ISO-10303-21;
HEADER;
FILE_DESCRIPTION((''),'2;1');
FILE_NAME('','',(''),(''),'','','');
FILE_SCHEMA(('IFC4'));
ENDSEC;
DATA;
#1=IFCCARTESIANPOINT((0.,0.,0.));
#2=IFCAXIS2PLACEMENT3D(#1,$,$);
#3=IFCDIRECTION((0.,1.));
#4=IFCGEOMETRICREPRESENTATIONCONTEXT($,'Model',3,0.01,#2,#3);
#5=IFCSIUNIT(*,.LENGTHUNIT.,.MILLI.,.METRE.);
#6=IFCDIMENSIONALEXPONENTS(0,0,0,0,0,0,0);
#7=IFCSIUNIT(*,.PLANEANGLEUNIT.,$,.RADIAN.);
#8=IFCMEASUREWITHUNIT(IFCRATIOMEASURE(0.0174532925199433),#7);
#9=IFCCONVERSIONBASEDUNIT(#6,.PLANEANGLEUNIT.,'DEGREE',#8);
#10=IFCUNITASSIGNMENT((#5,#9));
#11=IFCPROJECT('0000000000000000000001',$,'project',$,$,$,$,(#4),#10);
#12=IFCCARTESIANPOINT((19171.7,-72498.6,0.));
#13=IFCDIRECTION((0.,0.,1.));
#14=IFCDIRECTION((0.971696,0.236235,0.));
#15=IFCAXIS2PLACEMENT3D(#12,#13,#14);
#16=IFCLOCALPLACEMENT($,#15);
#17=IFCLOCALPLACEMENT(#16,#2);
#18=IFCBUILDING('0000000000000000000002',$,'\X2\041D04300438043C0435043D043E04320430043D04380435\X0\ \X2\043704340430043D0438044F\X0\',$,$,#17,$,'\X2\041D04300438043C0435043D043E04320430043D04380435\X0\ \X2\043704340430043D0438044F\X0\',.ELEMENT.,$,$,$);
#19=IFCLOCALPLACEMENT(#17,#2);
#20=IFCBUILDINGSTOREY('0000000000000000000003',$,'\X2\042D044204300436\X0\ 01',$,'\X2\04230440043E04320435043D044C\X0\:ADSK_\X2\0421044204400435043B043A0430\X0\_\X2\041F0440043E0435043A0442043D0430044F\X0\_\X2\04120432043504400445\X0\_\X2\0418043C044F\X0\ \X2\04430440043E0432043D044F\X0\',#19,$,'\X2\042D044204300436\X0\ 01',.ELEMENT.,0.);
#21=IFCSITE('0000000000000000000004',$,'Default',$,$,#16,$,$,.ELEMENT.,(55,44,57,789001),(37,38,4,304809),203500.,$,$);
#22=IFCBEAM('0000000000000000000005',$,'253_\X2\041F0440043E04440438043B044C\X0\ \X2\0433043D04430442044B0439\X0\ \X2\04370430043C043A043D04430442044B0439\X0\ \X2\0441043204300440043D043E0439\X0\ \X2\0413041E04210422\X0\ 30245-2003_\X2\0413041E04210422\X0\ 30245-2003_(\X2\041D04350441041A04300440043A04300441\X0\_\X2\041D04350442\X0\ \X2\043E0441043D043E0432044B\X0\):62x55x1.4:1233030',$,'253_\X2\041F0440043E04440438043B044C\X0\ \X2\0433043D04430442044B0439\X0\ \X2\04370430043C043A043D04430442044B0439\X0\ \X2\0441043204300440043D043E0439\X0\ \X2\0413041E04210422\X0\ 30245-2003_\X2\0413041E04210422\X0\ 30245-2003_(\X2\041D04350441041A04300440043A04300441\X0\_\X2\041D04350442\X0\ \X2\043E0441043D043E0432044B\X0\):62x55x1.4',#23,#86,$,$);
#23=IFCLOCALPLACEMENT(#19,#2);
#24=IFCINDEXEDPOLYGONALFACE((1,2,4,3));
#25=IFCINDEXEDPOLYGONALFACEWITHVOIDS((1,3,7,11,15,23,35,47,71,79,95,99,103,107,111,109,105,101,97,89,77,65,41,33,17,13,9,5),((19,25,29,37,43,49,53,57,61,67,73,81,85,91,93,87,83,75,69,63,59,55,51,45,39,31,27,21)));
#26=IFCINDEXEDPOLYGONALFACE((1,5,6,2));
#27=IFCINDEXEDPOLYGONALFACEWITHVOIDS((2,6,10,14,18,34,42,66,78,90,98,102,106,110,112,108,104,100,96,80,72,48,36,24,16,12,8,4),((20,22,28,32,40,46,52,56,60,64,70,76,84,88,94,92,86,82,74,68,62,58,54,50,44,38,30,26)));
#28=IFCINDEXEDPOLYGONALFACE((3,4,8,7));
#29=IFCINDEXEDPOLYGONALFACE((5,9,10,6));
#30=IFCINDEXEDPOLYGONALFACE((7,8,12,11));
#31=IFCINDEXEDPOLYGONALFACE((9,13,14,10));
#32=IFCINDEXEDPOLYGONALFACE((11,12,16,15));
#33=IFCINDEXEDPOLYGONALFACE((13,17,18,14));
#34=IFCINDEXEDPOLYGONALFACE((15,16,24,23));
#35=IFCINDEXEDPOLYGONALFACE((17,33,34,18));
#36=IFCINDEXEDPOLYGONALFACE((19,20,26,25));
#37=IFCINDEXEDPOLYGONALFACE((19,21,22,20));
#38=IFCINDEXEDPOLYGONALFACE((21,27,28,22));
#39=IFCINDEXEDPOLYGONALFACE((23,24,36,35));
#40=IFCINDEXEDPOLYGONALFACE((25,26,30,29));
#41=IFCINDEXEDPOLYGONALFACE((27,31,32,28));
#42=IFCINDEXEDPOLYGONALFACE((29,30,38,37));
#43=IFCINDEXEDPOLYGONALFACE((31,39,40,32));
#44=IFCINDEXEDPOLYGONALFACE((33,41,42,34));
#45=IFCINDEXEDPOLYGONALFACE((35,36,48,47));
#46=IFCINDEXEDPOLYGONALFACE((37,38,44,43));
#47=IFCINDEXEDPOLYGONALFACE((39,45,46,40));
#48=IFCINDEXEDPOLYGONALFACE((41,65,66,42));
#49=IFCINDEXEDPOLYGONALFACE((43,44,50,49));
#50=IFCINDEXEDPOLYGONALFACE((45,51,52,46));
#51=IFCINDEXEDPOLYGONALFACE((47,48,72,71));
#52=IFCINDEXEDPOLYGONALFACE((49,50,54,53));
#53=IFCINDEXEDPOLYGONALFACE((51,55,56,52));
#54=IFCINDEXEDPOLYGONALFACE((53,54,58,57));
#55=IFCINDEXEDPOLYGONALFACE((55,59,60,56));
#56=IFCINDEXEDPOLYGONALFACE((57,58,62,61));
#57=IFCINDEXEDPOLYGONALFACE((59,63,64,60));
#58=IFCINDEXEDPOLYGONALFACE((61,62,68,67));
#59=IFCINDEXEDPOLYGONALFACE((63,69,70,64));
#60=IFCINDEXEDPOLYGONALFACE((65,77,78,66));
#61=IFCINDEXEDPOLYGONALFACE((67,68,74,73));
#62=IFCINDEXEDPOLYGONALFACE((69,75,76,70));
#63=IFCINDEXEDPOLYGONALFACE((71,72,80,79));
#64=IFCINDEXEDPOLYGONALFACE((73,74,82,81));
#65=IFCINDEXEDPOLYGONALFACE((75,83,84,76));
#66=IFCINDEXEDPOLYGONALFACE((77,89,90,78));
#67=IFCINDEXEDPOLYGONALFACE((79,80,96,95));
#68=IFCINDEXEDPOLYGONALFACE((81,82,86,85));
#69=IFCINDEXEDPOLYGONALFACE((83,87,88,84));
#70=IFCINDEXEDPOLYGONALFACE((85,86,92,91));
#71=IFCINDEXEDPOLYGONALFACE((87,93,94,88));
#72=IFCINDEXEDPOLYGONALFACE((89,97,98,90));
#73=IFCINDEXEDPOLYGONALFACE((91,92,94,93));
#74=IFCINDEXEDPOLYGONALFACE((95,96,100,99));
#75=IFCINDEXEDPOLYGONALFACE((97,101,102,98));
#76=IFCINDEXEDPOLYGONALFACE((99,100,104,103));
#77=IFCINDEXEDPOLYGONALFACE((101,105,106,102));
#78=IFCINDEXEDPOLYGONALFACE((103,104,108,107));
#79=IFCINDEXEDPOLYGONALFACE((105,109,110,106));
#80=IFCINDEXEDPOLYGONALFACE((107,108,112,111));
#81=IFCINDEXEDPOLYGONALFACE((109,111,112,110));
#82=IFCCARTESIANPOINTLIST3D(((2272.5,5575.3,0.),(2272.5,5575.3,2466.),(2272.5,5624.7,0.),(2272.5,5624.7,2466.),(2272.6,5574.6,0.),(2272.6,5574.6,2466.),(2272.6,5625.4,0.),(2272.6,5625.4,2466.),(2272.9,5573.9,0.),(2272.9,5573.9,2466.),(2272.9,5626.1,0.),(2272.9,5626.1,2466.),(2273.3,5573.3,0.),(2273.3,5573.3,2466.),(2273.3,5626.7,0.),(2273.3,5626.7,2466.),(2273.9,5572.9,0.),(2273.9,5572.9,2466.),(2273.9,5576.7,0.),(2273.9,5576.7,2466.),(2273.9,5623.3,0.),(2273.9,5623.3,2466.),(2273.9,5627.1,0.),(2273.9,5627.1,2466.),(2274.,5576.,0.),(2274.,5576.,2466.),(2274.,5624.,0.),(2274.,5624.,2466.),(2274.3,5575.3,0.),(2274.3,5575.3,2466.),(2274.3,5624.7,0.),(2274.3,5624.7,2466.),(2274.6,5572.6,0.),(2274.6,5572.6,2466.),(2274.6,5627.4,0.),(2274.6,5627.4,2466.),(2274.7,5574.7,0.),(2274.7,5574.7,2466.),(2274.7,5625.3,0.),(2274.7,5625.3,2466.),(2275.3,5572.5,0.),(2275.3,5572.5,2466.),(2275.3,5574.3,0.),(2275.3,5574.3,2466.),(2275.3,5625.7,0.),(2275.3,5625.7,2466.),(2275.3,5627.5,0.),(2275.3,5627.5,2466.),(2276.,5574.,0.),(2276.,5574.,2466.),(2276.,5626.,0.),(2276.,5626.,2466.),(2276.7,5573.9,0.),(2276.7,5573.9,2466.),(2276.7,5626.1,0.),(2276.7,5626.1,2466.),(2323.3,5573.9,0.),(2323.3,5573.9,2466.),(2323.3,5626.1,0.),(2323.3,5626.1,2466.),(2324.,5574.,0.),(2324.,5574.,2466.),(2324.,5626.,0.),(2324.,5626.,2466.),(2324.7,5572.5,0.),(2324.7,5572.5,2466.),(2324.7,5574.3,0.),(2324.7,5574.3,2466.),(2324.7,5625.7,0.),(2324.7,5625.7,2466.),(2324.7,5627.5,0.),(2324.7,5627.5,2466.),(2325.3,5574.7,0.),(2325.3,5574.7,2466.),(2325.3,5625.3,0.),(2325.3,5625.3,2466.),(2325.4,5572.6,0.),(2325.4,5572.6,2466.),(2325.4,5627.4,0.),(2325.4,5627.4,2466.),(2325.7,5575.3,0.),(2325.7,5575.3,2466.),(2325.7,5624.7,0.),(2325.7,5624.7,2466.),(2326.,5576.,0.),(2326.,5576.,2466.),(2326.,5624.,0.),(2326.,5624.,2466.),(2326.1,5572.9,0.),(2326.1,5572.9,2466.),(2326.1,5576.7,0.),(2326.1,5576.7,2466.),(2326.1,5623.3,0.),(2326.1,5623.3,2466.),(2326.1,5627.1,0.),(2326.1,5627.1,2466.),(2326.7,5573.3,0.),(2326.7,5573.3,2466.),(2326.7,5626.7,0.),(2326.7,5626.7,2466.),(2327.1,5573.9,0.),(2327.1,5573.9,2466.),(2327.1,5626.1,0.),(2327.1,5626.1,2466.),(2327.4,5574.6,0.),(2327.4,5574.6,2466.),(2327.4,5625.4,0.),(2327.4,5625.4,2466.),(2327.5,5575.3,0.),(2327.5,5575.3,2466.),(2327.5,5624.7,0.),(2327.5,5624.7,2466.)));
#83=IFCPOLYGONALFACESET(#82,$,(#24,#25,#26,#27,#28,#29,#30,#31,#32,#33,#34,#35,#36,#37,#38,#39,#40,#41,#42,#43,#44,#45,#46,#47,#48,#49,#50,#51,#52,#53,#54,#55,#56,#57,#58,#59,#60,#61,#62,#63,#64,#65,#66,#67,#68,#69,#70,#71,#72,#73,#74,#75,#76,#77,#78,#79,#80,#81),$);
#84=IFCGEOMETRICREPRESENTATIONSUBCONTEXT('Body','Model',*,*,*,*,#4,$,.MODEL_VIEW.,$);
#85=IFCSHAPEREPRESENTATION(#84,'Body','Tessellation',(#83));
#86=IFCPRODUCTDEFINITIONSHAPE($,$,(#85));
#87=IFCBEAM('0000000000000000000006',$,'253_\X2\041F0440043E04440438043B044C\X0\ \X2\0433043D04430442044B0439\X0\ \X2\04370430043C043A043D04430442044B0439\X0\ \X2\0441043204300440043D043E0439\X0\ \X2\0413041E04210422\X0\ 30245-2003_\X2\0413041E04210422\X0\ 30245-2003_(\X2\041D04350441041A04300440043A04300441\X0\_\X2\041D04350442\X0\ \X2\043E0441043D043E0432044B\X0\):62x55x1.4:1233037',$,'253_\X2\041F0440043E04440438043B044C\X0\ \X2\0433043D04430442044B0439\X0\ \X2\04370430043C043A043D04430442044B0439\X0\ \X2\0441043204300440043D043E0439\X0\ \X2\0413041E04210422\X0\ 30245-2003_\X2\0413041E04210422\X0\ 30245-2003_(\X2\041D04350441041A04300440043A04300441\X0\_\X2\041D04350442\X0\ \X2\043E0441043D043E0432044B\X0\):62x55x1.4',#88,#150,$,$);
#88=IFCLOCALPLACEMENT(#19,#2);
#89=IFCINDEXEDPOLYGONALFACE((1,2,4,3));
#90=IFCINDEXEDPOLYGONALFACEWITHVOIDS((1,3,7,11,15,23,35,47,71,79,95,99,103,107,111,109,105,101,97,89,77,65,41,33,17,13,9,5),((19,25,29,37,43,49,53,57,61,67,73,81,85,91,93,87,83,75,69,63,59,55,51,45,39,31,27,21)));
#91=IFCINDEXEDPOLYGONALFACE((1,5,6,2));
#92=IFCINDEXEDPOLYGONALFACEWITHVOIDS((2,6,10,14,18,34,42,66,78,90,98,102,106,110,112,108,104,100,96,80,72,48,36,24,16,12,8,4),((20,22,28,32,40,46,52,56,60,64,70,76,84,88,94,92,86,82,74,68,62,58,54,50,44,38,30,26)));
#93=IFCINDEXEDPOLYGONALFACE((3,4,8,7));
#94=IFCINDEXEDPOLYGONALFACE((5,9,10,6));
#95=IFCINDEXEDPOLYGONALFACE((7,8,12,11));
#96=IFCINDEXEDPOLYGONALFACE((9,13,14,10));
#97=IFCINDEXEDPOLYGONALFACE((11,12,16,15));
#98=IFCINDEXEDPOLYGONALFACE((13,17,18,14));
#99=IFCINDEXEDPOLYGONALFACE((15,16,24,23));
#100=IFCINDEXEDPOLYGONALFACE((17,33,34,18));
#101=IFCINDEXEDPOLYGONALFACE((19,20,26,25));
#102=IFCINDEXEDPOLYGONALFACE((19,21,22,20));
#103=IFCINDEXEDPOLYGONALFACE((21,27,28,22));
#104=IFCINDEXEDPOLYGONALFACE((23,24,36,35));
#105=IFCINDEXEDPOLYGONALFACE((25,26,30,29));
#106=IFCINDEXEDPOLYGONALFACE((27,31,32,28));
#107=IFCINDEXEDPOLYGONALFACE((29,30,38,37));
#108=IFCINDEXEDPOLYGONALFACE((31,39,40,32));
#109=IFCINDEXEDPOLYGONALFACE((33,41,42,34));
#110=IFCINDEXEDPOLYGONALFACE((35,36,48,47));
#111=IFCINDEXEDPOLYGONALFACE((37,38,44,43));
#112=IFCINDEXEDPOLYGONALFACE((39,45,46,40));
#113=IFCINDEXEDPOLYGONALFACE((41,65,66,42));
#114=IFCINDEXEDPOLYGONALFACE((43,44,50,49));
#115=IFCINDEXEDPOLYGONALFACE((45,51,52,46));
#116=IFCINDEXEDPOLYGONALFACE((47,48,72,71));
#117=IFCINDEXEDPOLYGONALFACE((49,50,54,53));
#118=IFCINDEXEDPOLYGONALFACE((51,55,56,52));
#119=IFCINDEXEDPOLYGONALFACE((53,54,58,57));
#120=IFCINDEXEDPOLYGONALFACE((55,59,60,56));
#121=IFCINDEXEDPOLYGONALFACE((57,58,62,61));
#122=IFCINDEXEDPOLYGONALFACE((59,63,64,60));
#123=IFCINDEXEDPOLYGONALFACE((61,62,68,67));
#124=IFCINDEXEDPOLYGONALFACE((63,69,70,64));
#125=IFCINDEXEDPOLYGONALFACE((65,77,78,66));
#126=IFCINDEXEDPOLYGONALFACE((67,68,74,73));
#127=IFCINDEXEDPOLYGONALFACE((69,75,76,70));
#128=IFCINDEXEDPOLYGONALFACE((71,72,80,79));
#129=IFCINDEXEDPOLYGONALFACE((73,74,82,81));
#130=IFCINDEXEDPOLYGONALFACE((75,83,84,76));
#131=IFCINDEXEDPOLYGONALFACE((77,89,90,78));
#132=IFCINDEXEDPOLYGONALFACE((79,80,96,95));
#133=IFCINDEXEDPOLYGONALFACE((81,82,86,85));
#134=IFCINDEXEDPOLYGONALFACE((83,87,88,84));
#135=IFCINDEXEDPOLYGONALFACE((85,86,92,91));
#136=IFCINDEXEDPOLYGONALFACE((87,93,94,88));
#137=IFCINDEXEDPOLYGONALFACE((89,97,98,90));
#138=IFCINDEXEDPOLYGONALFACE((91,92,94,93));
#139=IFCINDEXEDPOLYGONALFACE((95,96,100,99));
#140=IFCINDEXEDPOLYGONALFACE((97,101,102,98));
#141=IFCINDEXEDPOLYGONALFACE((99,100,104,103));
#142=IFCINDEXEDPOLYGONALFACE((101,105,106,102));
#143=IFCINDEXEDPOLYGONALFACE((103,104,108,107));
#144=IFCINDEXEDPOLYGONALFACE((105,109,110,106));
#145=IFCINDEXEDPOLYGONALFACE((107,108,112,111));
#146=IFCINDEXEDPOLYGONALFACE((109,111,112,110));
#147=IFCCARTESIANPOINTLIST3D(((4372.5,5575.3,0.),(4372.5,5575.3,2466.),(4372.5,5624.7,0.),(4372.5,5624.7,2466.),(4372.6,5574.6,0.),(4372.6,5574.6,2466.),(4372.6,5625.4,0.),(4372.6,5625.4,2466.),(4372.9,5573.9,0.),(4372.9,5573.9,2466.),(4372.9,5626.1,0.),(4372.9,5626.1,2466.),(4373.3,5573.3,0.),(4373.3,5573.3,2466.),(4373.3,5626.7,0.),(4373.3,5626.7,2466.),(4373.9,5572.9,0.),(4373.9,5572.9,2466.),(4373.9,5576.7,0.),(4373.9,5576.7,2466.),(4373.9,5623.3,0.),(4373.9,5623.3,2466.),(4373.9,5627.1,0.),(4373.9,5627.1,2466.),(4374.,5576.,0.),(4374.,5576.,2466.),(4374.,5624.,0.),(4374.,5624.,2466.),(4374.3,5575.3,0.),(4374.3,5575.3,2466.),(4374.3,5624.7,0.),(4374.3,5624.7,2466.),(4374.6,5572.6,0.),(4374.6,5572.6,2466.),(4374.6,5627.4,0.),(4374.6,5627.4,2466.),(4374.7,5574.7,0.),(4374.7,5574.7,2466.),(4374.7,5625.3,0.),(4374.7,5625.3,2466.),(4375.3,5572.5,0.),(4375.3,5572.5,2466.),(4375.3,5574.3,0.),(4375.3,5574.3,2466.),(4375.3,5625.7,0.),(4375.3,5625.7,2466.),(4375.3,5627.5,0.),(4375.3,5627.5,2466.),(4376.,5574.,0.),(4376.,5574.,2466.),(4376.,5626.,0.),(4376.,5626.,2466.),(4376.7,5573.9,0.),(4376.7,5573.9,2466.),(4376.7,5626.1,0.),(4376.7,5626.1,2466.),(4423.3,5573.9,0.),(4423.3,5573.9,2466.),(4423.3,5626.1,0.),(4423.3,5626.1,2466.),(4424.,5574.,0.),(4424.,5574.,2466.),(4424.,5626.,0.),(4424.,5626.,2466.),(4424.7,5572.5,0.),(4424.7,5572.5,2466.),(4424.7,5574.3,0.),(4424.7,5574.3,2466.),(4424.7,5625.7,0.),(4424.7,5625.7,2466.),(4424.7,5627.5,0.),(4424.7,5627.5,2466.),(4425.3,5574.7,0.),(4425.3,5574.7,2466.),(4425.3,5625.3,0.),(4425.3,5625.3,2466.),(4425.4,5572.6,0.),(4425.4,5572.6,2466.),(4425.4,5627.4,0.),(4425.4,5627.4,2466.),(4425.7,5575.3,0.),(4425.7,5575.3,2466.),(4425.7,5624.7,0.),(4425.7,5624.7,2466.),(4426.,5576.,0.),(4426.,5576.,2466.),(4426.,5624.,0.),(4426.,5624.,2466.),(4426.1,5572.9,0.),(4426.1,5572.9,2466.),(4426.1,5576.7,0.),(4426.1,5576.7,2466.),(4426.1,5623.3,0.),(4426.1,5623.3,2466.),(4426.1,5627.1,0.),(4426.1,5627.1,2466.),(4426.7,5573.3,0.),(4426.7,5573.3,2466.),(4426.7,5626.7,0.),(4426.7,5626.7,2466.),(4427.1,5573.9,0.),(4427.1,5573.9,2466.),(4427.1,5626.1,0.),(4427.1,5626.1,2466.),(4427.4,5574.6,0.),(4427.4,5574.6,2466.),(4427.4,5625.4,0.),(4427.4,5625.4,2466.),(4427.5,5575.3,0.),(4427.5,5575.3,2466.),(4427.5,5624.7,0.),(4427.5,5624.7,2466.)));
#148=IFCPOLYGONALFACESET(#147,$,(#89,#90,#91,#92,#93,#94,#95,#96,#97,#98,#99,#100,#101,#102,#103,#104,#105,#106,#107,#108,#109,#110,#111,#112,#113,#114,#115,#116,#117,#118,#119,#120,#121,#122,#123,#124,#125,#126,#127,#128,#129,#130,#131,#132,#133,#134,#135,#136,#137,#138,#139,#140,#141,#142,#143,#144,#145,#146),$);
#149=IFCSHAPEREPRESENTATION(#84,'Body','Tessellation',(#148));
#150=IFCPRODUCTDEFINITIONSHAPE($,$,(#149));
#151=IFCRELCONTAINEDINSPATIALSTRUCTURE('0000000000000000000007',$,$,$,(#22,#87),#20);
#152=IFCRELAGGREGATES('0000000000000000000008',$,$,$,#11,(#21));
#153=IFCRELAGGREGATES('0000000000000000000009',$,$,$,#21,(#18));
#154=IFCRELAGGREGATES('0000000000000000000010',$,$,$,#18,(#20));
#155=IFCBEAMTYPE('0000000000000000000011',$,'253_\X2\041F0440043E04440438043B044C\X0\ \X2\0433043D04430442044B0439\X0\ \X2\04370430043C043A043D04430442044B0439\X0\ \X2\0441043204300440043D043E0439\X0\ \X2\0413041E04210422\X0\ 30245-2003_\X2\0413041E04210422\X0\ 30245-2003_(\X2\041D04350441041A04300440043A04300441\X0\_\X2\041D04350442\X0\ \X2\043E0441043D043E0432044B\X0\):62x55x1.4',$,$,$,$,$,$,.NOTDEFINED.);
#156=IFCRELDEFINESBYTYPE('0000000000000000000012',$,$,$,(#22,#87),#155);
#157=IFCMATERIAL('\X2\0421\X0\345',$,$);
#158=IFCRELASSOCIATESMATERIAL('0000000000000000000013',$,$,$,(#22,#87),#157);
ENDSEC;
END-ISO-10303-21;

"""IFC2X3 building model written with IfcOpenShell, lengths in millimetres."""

from ifc_helpers import new_model, entity, si_unit, converted_unit, direction, frame, frame_2d, origin, place, context, subcontext, project, spatial, polyline, circle_curve, parameter, trimmed, segment, composite_curve, outline, extrude, material, type_object, element, save


model = new_model("IFC2X3")

# Units and contexts
model_context = context("Model", 3, precision=0.01, world=origin(), true_north=direction((0.0, 1.0)))
body_context = subcontext(model_context, "Body", "Model", "MODEL_VIEW")
ifc_project = project(units=[si_unit("LENGTHUNIT", "METRE", prefix="MILLI"), converted_unit("PLANEANGLEUNIT", "DEGREE", entity("IfcRatioMeasure", 0.0174532925199433), si_unit("PLANEANGLEUNIT", "RADIAN"), dimensions=[0, 0, 0, 0, 0, 0, 0])], contexts=[model_context])

# Site, building, storey
site_placement = place(None, frame((19171.7, -72498.6, 0.0), z_axis=(0.0, 0.0, 1.0), x_axis=(0.971696, 0.236235, 0.0)))
site = spatial("IfcSite", under=ifc_project, at=site_placement, Name="Default", CompositionType="ELEMENT", RefLatitude=(55, 44, 57, 789001), RefLongitude=(37, 38, 4, 304809), RefElevation=203500.0)
building_placement = place(site_placement, origin())
building = spatial("IfcBuilding", under=site, at=building_placement, Name="Наименование здания", LongName="Наименование здания", CompositionType="ELEMENT")
storey_placement = place(building_placement, origin())
storey = spatial("IfcBuildingStorey", under=building, at=storey_placement, Name="Этаж 01", ObjectType="Уровень:ADSK_Стрелка_Проектная_Вверх_Имя уровня", LongName="Этаж 01", CompositionType="ELEMENT", Elevation=0.0)

# Beams
ifc_material_1 = material(Name="С345")
beam_type_1 = type_object("IfcBeamType", Name="253_Профиль гнутый замкнутый сварной ГОСТ 30245-2003_ГОСТ 30245-2003_(НесКаркас_Нет основы):62x55x1.4", PredefinedType="NOTDEFINED")
beam_1_placement = place(storey_placement, frame((2270.9, 5570.9, 0.0), z_axis=(1.0, 0.0, 0.0), x_axis=(0.0, 0.0, -1.0)))
element("IfcBeam", 1, at=beam_1_placement, inside=storey, type_object=beam_type_1, material=ifc_material_1, Name="253_Профиль гнутый замкнутый сварной ГОСТ 30245-2003_ГОСТ 30245-2003_(НесКаркас_Нет основы):62x55x1.4:1233030", ObjectType="253_Профиль гнутый замкнутый сварной ГОСТ 30245-2003_ГОСТ 30245-2003_(НесКаркас_Нет основы):62x55x1.4", context=body_context, shape_type="SweptSolid", body=[
    extrude(outline(composite_curve([segment(trimmed(circle_curve(frame_2d((24.7, -24.7), x_axis=(1.0, 0.0)), 2.8), [parameter(270.0)], [parameter(0.0)], True, "PARAMETER"), True, "CONTINUOUS"), segment(polyline([(27.5, -24.7), (27.5, 24.7)]), True, "CONTINUOUS"), segment(trimmed(circle_curve(frame_2d((24.7, 24.7), x_axis=(1.0, 0.0)), 2.8), [parameter(0.0)], [parameter(90.0)], True, "PARAMETER"), True, "CONTINUOUS"), segment(polyline([(24.7, 27.5), (-24.7, 27.5)]), True, "CONTINUOUS"), segment(trimmed(circle_curve(frame_2d((-24.7, 24.7), x_axis=(1.0, 0.0)), 2.8), [parameter(90.0)], [parameter(180.0)], True, "PARAMETER"), True, "CONTINUOUS"), segment(polyline([(-27.5, 24.7), (-27.5, -24.7)]), True, "CONTINUOUS"), segment(trimmed(circle_curve(frame_2d((-24.7, -24.7), x_axis=(1.0, 0.0)), 2.8), [parameter(180.0)], [parameter(270.0)], True, "PARAMETER"), True, "CONTINUOUS"), segment(polyline([(-24.7, -27.5), (24.7, -27.5)]), True, "CONTINUOUS")], self_intersect=False), holes=[composite_curve([segment(polyline([(23.3, -26.1), (-23.3, -26.1)]), True, "CONTINUOUS"), segment(trimmed(circle_curve(frame_2d((-23.3, -23.3), x_axis=(1.0, 0.0)), 2.8), [parameter(180.0)], [parameter(270.0)], True, "PARAMETER"), False, "CONTINUOUS"), segment(polyline([(-26.1, -23.3), (-26.1, 23.3)]), True, "CONTINUOUS"), segment(trimmed(circle_curve(frame_2d((-23.3, 23.3), x_axis=(1.0, 0.0)), 2.8), [parameter(90.0)], [parameter(180.0)], True, "PARAMETER"), False, "CONTINUOUS"), segment(polyline([(-23.3, 26.1), (23.3, 26.1)]), True, "CONTINUOUS"), segment(trimmed(circle_curve(frame_2d((23.3, 23.3), x_axis=(1.0, 0.0)), 2.8), [parameter(0.0)], [parameter(90.0)], True, "PARAMETER"), False, "CONTINUOUS"), segment(polyline([(26.1, 23.3), (26.1, -23.3)]), True, "CONTINUOUS"), segment(trimmed(circle_curve(frame_2d((23.3, -23.3), x_axis=(1.0, 0.0)), 2.8), [parameter(270.0)], [parameter(0.0)], True, "PARAMETER"), False, "CONTINUOUS")], self_intersect=False)]), frame((-2466.0, 29.1, 29.1), z_axis=(1.0, 0.0, 0.0), x_axis=(0.0, 1.0, 0.0)), (0.0, 0.0, 1.0), 2466.0),
])
beam_2_placement = place(storey_placement, frame((4370.9, 5570.9, 0.0), z_axis=(1.0, 0.0, 0.0), x_axis=(0.0, 0.0, -1.0)))
element("IfcBeam", 2, at=beam_2_placement, inside=storey, type_object=beam_type_1, material=ifc_material_1, Name="253_Профиль гнутый замкнутый сварной ГОСТ 30245-2003_ГОСТ 30245-2003_(НесКаркас_Нет основы):62x55x1.4:1233037", ObjectType="253_Профиль гнутый замкнутый сварной ГОСТ 30245-2003_ГОСТ 30245-2003_(НесКаркас_Нет основы):62x55x1.4", context=body_context, shape_type="SweptSolid", body=[
    extrude(outline(composite_curve([segment(trimmed(circle_curve(frame_2d((24.7, -24.7), x_axis=(1.0, 0.0)), 2.8), [parameter(270.0)], [parameter(0.0)], True, "PARAMETER"), True, "CONTINUOUS"), segment(polyline([(27.5, -24.7), (27.5, 24.7)]), True, "CONTINUOUS"), segment(trimmed(circle_curve(frame_2d((24.7, 24.7), x_axis=(1.0, 0.0)), 2.8), [parameter(0.0)], [parameter(90.0)], True, "PARAMETER"), True, "CONTINUOUS"), segment(polyline([(24.7, 27.5), (-24.7, 27.5)]), True, "CONTINUOUS"), segment(trimmed(circle_curve(frame_2d((-24.7, 24.7), x_axis=(1.0, 0.0)), 2.8), [parameter(90.0)], [parameter(180.0)], True, "PARAMETER"), True, "CONTINUOUS"), segment(polyline([(-27.5, 24.7), (-27.5, -24.7)]), True, "CONTINUOUS"), segment(trimmed(circle_curve(frame_2d((-24.7, -24.7), x_axis=(1.0, 0.0)), 2.8), [parameter(180.0)], [parameter(270.0)], True, "PARAMETER"), True, "CONTINUOUS"), segment(polyline([(-24.7, -27.5), (24.7, -27.5)]), True, "CONTINUOUS")], self_intersect=False), holes=[composite_curve([segment(polyline([(23.3, -26.1), (-23.3, -26.1)]), True, "CONTINUOUS"), segment(trimmed(circle_curve(frame_2d((-23.3, -23.3), x_axis=(1.0, 0.0)), 2.8), [parameter(180.0)], [parameter(270.0)], True, "PARAMETER"), False, "CONTINUOUS"), segment(polyline([(-26.1, -23.3), (-26.1, 23.3)]), True, "CONTINUOUS"), segment(trimmed(circle_curve(frame_2d((-23.3, 23.3), x_axis=(1.0, 0.0)), 2.8), [parameter(90.0)], [parameter(180.0)], True, "PARAMETER"), False, "CONTINUOUS"), segment(polyline([(-23.3, 26.1), (23.3, 26.1)]), True, "CONTINUOUS"), segment(trimmed(circle_curve(frame_2d((23.3, 23.3), x_axis=(1.0, 0.0)), 2.8), [parameter(0.0)], [parameter(90.0)], True, "PARAMETER"), False, "CONTINUOUS"), segment(polyline([(26.1, 23.3), (26.1, -23.3)]), True, "CONTINUOUS"), segment(trimmed(circle_curve(frame_2d((23.3, -23.3), x_axis=(1.0, 0.0)), 2.8), [parameter(270.0)], [parameter(0.0)], True, "PARAMETER"), False, "CONTINUOUS")], self_intersect=False)]), frame((-2466.0, 29.1, 29.1), z_axis=(1.0, 0.0, 0.0), x_axis=(0.0, 1.0, 0.0)), (0.0, 0.0, 1.0), 2466.0),
])

save(model, "model.ifc")
